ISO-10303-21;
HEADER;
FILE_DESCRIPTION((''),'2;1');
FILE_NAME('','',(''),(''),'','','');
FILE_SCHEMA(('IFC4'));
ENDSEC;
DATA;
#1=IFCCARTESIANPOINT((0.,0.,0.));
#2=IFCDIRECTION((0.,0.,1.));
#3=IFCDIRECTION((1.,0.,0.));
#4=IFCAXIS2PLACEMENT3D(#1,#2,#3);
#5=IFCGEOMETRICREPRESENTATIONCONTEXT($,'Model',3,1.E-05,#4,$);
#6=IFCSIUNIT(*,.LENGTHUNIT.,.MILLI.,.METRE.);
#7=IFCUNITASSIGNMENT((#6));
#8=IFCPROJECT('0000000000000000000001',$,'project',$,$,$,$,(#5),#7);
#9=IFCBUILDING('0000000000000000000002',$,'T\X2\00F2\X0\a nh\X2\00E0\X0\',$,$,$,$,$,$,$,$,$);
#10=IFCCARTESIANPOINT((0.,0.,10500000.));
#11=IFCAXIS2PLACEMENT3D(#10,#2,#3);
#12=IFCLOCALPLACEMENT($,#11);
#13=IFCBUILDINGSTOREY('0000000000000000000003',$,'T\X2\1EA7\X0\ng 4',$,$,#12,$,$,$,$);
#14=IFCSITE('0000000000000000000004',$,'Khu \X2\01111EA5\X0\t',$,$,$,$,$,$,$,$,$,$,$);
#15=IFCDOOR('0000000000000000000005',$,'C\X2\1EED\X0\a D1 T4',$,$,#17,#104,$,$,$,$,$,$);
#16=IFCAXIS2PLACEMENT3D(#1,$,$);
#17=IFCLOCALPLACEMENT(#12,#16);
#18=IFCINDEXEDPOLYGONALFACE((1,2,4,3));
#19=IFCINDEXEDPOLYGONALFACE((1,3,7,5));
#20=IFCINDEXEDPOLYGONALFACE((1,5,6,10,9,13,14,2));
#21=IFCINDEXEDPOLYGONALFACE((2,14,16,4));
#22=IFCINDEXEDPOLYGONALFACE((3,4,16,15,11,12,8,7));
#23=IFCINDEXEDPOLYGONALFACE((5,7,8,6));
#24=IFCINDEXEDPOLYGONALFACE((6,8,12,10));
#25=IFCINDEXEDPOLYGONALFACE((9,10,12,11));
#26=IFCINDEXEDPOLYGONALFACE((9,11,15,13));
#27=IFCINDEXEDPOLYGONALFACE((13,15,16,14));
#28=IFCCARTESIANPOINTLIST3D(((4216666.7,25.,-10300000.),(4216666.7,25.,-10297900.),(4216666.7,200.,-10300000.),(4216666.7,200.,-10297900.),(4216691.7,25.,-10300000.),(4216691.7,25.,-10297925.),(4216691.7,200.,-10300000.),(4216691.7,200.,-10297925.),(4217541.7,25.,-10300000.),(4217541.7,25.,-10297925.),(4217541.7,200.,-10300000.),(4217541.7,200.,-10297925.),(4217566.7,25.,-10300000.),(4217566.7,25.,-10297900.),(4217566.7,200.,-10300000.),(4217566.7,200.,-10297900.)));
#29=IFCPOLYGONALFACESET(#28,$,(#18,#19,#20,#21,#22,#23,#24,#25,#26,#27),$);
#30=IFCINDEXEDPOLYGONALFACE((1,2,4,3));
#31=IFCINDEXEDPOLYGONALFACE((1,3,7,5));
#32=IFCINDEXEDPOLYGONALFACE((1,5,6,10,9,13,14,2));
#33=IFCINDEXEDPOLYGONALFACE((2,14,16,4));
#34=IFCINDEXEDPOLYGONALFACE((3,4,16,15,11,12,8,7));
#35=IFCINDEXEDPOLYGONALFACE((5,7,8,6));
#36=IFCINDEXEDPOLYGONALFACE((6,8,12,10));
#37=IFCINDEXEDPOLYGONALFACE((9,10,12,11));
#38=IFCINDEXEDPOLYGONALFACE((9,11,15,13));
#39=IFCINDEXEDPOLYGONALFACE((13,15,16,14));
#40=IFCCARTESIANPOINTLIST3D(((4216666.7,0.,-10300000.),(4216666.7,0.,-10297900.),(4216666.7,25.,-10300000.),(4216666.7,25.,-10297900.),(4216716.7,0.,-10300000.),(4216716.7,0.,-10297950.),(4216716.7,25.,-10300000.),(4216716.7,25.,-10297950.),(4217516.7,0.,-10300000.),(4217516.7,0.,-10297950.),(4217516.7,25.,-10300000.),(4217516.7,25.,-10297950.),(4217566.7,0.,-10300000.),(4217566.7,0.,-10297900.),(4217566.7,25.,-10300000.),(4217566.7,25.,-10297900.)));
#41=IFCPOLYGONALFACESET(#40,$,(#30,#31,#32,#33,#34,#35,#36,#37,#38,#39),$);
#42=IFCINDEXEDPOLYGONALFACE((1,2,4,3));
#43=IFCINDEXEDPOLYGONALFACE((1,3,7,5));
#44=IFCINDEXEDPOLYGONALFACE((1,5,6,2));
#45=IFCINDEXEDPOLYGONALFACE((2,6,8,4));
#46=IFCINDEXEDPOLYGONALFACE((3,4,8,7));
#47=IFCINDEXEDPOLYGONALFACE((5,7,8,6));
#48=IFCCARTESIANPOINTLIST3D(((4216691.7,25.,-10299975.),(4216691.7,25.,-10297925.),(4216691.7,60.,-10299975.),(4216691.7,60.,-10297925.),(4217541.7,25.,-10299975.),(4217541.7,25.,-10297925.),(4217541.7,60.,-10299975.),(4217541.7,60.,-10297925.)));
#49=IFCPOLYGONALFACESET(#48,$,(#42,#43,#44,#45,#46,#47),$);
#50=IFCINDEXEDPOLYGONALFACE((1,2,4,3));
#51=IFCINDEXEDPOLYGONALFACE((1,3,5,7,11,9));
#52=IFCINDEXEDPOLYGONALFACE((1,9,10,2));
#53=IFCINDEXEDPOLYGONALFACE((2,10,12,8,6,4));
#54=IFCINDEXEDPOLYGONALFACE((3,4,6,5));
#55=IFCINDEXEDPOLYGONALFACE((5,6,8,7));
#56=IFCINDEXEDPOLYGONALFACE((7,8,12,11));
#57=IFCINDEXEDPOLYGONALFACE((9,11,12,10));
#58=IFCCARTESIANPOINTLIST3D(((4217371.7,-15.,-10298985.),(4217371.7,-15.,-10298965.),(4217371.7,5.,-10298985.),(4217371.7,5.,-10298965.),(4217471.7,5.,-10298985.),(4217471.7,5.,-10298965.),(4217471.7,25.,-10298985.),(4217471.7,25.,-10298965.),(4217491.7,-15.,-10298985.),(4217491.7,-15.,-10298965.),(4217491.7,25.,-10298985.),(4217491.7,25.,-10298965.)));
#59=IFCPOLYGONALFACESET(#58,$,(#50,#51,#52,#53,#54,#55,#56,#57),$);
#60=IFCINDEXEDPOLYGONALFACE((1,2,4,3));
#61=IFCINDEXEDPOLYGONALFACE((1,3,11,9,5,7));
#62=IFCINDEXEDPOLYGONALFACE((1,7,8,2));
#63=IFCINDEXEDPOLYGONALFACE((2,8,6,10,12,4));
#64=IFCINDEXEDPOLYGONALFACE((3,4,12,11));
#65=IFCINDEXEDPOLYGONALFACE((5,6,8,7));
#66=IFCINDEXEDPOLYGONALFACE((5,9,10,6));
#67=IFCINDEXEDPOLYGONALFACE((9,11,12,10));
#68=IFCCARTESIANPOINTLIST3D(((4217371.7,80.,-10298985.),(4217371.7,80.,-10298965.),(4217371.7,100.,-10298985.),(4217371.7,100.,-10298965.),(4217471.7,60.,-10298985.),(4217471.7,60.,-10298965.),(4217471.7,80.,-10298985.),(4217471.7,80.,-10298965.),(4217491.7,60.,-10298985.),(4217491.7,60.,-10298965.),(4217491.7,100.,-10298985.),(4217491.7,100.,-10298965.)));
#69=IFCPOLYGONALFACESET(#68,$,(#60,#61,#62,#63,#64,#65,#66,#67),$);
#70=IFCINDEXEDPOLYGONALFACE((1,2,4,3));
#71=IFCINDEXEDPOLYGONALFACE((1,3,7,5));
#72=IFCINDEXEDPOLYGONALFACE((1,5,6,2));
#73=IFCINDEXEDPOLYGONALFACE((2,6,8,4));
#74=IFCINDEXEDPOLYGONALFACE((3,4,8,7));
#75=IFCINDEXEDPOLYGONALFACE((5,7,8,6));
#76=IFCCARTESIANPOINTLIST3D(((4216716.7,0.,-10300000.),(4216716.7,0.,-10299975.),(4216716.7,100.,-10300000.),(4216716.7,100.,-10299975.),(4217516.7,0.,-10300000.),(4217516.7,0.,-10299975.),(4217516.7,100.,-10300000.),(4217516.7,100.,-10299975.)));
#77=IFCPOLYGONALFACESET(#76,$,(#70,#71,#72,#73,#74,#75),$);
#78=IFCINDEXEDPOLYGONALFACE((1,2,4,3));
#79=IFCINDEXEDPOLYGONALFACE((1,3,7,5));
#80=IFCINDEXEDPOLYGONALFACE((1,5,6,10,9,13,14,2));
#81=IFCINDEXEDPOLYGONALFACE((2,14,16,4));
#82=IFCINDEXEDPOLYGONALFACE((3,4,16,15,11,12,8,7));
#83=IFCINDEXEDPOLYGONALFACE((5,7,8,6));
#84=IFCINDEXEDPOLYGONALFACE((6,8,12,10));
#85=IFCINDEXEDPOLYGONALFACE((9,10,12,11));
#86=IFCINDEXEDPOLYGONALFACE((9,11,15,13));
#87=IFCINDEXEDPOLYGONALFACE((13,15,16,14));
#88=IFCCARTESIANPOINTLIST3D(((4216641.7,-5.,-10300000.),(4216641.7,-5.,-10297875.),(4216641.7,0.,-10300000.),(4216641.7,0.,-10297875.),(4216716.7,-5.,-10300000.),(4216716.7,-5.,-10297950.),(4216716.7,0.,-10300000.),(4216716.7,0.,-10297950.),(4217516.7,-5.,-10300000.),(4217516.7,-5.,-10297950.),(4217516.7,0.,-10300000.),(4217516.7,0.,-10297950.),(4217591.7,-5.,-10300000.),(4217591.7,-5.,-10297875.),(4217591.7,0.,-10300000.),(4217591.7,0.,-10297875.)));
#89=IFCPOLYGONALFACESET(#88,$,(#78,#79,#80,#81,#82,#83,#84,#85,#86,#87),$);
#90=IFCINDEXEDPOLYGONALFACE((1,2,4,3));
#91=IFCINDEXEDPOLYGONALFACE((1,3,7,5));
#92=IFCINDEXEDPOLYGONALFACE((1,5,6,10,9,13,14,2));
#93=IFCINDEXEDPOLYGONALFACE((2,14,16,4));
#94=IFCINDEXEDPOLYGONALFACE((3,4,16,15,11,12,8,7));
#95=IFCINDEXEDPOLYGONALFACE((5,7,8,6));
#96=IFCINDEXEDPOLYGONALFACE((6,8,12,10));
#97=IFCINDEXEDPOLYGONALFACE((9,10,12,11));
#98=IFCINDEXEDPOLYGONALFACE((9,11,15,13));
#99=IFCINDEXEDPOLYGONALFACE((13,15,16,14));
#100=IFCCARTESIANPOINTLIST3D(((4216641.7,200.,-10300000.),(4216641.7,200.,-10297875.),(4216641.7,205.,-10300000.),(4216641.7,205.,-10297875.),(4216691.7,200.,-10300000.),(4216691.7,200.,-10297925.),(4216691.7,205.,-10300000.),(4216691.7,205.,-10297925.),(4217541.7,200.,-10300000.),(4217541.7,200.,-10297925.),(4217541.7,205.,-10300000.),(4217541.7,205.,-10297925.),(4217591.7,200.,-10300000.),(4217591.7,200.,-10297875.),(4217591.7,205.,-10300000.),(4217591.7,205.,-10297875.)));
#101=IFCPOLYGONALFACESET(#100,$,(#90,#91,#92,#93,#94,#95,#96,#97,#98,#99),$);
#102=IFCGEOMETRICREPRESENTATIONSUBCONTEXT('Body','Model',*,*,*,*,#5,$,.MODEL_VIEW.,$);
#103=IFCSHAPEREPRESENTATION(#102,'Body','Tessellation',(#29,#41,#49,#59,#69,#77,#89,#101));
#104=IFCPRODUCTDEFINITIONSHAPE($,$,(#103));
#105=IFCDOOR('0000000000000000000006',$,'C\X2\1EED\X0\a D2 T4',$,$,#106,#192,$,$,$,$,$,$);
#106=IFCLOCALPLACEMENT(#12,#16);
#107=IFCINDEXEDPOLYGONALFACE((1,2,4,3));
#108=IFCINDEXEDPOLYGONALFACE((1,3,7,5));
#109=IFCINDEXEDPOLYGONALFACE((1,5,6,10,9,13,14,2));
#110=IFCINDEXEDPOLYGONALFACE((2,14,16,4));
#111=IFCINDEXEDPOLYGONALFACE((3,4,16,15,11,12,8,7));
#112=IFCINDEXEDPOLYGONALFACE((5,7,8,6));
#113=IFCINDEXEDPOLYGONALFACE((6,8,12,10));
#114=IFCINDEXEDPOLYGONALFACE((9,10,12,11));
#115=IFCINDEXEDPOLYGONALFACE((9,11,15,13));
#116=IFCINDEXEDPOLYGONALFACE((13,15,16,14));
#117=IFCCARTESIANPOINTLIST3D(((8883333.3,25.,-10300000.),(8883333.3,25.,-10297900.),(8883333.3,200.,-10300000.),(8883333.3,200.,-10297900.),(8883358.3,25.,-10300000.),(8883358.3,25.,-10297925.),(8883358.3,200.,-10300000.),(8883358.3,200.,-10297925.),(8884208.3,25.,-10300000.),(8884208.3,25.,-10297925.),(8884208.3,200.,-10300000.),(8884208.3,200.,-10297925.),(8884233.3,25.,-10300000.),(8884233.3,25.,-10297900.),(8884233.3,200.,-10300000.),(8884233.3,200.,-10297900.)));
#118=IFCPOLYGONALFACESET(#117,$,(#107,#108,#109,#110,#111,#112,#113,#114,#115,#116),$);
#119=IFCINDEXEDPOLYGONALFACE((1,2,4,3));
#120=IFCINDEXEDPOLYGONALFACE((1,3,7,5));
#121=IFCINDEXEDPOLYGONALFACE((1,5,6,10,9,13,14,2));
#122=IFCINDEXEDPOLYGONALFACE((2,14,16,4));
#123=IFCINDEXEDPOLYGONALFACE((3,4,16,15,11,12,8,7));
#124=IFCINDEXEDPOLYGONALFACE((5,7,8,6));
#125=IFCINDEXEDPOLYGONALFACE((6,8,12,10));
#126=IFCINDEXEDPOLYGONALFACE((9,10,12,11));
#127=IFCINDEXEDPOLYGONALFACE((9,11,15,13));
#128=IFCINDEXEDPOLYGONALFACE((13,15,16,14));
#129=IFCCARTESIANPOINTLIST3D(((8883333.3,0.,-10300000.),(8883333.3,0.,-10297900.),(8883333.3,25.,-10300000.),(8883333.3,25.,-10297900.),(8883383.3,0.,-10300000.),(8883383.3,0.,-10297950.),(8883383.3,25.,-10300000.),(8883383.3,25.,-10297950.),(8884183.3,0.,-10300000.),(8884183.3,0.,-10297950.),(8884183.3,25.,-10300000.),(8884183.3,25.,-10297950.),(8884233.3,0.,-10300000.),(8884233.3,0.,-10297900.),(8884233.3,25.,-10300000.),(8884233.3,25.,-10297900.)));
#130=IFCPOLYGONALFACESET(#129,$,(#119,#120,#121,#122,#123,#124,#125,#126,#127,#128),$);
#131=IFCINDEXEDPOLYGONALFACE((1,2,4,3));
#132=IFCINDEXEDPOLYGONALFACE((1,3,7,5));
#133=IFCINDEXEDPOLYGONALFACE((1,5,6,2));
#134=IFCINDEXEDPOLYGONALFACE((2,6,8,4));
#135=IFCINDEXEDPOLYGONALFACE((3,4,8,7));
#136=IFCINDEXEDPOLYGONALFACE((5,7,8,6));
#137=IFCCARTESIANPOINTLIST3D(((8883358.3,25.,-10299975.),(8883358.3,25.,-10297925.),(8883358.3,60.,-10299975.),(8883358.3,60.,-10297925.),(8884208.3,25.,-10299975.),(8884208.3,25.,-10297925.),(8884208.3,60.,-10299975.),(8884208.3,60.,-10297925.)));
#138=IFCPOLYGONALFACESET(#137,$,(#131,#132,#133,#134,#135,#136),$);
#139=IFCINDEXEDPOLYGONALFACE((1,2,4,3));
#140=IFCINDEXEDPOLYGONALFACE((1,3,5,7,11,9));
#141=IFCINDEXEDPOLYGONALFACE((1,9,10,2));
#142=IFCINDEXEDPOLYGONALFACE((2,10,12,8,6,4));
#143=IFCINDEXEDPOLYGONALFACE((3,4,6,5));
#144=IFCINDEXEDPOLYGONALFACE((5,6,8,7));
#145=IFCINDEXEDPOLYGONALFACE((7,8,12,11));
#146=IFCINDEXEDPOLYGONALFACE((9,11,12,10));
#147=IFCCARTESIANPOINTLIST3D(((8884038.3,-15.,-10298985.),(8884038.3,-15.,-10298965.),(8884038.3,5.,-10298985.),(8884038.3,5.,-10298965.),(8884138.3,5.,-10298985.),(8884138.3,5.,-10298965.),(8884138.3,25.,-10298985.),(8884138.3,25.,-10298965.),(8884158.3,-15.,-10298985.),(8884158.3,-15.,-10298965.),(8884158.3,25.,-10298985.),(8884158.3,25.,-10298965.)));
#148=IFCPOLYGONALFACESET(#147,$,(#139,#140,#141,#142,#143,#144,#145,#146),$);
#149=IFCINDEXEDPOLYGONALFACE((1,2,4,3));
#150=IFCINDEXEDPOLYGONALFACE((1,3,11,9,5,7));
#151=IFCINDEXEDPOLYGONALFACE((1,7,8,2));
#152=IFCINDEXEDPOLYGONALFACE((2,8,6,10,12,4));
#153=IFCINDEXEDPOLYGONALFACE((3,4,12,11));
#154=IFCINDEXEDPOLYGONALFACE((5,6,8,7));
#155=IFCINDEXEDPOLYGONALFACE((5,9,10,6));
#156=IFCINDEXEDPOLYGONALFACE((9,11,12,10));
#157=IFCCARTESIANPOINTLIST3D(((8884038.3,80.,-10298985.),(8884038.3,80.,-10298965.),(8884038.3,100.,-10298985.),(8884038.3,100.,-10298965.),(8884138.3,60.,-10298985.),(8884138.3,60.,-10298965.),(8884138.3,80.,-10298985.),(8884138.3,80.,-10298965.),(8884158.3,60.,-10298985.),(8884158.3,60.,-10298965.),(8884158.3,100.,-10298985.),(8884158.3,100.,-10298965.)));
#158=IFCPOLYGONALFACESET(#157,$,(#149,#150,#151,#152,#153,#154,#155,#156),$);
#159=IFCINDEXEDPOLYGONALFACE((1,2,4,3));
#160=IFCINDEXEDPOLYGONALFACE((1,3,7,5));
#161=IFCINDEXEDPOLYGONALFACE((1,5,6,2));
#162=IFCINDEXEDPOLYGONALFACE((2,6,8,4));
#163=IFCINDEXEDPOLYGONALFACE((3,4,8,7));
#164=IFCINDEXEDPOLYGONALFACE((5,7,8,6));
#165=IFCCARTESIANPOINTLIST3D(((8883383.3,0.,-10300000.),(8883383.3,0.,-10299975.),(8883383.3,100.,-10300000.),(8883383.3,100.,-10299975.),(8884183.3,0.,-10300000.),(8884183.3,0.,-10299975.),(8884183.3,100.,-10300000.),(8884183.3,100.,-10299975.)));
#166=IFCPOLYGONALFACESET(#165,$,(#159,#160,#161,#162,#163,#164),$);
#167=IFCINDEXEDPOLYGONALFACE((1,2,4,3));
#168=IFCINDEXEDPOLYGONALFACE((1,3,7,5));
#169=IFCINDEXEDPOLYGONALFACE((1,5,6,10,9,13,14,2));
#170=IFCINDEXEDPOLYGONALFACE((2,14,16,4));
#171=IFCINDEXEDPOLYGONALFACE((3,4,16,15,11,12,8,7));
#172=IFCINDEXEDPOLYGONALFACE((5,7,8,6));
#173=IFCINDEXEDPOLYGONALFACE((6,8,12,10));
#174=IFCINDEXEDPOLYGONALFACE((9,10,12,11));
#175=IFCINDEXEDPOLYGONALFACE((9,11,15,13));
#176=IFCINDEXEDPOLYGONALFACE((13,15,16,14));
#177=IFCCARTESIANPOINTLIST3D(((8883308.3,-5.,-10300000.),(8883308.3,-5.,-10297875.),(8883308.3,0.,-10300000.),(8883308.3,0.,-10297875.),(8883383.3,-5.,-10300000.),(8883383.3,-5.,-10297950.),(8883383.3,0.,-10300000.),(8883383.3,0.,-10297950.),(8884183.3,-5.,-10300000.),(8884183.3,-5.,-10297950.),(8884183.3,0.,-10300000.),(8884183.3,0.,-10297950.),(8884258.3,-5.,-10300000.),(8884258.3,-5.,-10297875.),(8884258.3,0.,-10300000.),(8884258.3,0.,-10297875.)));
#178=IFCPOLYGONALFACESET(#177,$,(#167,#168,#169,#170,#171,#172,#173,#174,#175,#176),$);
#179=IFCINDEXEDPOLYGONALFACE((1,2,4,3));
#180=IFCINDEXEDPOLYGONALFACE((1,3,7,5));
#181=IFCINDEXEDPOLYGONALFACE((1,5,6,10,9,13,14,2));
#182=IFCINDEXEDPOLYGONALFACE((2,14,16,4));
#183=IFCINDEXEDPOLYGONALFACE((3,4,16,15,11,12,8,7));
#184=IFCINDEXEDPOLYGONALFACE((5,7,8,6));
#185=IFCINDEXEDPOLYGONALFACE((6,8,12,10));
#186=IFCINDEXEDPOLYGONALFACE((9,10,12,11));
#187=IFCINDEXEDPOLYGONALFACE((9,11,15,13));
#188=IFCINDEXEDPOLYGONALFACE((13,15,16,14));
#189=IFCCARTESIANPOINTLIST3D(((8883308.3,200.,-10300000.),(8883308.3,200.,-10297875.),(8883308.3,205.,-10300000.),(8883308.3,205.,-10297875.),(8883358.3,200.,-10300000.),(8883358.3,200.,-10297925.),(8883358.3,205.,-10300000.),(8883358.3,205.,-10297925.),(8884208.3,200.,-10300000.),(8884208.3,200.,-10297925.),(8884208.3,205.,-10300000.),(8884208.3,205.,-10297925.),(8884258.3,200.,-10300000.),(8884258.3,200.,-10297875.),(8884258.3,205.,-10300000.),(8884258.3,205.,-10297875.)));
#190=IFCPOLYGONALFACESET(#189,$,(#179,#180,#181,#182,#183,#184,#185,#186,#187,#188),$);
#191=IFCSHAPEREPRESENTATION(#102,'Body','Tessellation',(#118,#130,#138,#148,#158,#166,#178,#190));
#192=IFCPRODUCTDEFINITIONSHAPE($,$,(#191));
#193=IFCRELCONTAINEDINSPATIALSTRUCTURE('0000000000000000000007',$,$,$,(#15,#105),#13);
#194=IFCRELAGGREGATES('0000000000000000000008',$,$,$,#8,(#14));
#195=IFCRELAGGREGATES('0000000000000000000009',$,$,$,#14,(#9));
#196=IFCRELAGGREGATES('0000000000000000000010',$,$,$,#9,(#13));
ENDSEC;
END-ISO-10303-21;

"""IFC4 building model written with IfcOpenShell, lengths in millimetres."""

from ifc_helpers import new_model, si_unit, frame, origin_with_axes, place, context, subcontext, project, spatial, line, indexed_curve, outline, extrude, element, save


model = new_model("IFC4")

# Units and contexts
model_context = context("Model", 3, precision=1e-05, world=origin_with_axes())
body_context = subcontext(model_context, "Body", "Model", "MODEL_VIEW")
ifc_project = project(units=[si_unit("LENGTHUNIT", "METRE", prefix="MILLI")], contexts=[model_context])

# Site, building, storey
site = spatial("IfcSite", under=ifc_project, Name="Khu đất")
building = spatial("IfcBuilding", under=site, Name="Tòa nhà")
storey_placement = place(None, frame((0.0, 0.0, 10500000.0), z_axis=(0.0, 0.0, 1.0), x_axis=(1.0, 0.0, 0.0)))
storey = spatial("IfcBuildingStorey", under=building, at=storey_placement, Name="Tầng 4")

# Doors
door_1_placement = place(storey_placement, frame((4216666.7, 0.0, -10300000.0), z_axis=(0.0, 0.0, 1.0), x_axis=(1.0, 0.0, 0.0)))
element("IfcDoor", 1, at=door_1_placement, inside=storey, Name="Cửa D1 T4", context=body_context, shape_type="SolidModel", body=[
    extrude(outline(indexed_curve([(0.0, 0.0), (0.0, 2100.0), (900.0, 2100.0), (900.0, 0.0), (875.0, 0.0), (875.0, 2075.0), (25.0, 2075.0), (25.0, 0.0)], segments=[line(1, 2, 3, 4, 5, 6, 7, 8, 1)])), frame((0.0, 25.0, 0.0), z_axis=(0.0, -1.0, 0.0), x_axis=(1.0, 0.0, 0.0)), (0.0, 0.0, -1.0), 175.0),
    extrude(outline(indexed_curve([(0.0, 0.0), (0.0, 2100.0), (900.0, 2100.0), (900.0, 0.0), (850.0, 0.0), (850.0, 2050.0), (50.0, 2050.0), (50.0, 0.0)], segments=[line(1, 2, 3, 4, 5, 6, 7, 8, 1)])), frame((0.0, 0.0, 0.0), z_axis=(0.0, -1.0, 0.0), x_axis=(1.0, 0.0, 0.0)), (0.0, 0.0, -1.0), 25.0),
    extrude(outline(indexed_curve([(0.0, 0.0), (850.0, 0.0), (850.0, 35.0), (0.0, 35.0)], segments=[line(1, 2, 3, 4, 1)])), frame((25.0, 25.0, 25.0), z_axis=(0.0, 0.0, 1.0), x_axis=(1.0, 0.0, 0.0)), (0.0, 0.0, 1.0), 2050.0),
    extrude(outline(indexed_curve([(0.0, 0.0), (0.0, -40.0), (-120.0, -40.0), (-120.0, -20.0), (-20.0, -20.0), (-20.0, 0.0)], segments=[line(1, 2, 3, 4, 5, 6, 1)])), frame((825.0, 25.0, 1015.0), z_axis=(0.0, 0.0, 1.0), x_axis=(1.0, 0.0, 0.0)), (0.0, 0.0, 1.0), 20.0),
    extrude(outline(indexed_curve([(0.0, 0.0), (0.0, 40.0), (-120.0, 40.0), (-120.0, 20.0), (-20.0, 20.0), (-20.0, 0.0)], segments=[line(1, 2, 3, 4, 5, 6, 1)])), frame((825.0, 60.0, 1015.0), z_axis=(0.0, 0.0, 1.0), x_axis=(1.0, 0.0, 0.0)), (0.0, 0.0, 1.0), 20.0),
    extrude(outline(indexed_curve([(0.0, 0.0), (800.0, 0.0), (800.0, 100.0), (0.0, 100.0)], segments=[line(1, 2, 3, 4, 1)])), frame((50.0, 0.0, 0.0), z_axis=(0.0, 0.0, 1.0), x_axis=(1.0, 0.0, 0.0)), (0.0, 0.0, 1.0), 25.0),
    extrude(outline(indexed_curve([(0.0, 0.0), (0.0, 2125.0), (950.0, 2125.0), (950.0, 0.0), (875.0, 0.0), (875.0, 2050.0), (75.0, 2050.0), (75.0, 0.0)], segments=[line(1, 2, 3, 4, 5, 6, 7, 8, 1)])), frame((-25.0, -5.0, 0.0), z_axis=(0.0, -1.0, 0.0), x_axis=(1.0, 0.0, 0.0)), (0.0, 0.0, -1.0), 5.0),
    extrude(outline(indexed_curve([(0.0, 0.0), (0.0, 2125.0), (950.0, 2125.0), (950.0, 0.0), (900.0, 0.0), (900.0, 2075.0), (50.0, 2075.0), (50.0, 0.0)], segments=[line(1, 2, 3, 4, 5, 6, 7, 8, 1)])), frame((-25.0, 200.0, 0.0), z_axis=(0.0, -1.0, 0.0), x_axis=(1.0, 0.0, 0.0)), (0.0, 0.0, -1.0), 5.0),
])
door_2_placement = place(storey_placement, frame((8883333.3, 0.0, -10300000.0), z_axis=(0.0, 0.0, 1.0), x_axis=(1.0, 0.0, 0.0)))
element("IfcDoor", 2, at=door_2_placement, inside=storey, Name="Cửa D2 T4", context=body_context, shape_type="SolidModel", body=[
    extrude(outline(indexed_curve([(0.0, 0.0), (0.0, 2100.0), (900.0, 2100.0), (900.0, 0.0), (875.0, 0.0), (875.0, 2075.0), (25.0, 2075.0), (25.0, 0.0)], segments=[line(1, 2, 3, 4, 5, 6, 7, 8, 1)])), frame((0.0, 25.0, 0.0), z_axis=(0.0, -1.0, 0.0), x_axis=(1.0, 0.0, 0.0)), (0.0, 0.0, -1.0), 175.0),
    extrude(outline(indexed_curve([(0.0, 0.0), (0.0, 2100.0), (900.0, 2100.0), (900.0, 0.0), (850.0, 0.0), (850.0, 2050.0), (50.0, 2050.0), (50.0, 0.0)], segments=[line(1, 2, 3, 4, 5, 6, 7, 8, 1)])), frame((0.0, 0.0, 0.0), z_axis=(0.0, -1.0, 0.0), x_axis=(1.0, 0.0, 0.0)), (0.0, 0.0, -1.0), 25.0),
    extrude(outline(indexed_curve([(0.0, 0.0), (850.0, 0.0), (850.0, 35.0), (0.0, 35.0)], segments=[line(1, 2, 3, 4, 1)])), frame((25.0, 25.0, 25.0), z_axis=(0.0, 0.0, 1.0), x_axis=(1.0, 0.0, 0.0)), (0.0, 0.0, 1.0), 2050.0),
    extrude(outline(indexed_curve([(0.0, 0.0), (0.0, -40.0), (-120.0, -40.0), (-120.0, -20.0), (-20.0, -20.0), (-20.0, 0.0)], segments=[line(1, 2, 3, 4, 5, 6, 1)])), frame((825.0, 25.0, 1015.0), z_axis=(0.0, 0.0, 1.0), x_axis=(1.0, 0.0, 0.0)), (0.0, 0.0, 1.0), 20.0),
    extrude(outline(indexed_curve([(0.0, 0.0), (0.0, 40.0), (-120.0, 40.0), (-120.0, 20.0), (-20.0, 20.0), (-20.0, 0.0)], segments=[line(1, 2, 3, 4, 5, 6, 1)])), frame((825.0, 60.0, 1015.0), z_axis=(0.0, 0.0, 1.0), x_axis=(1.0, 0.0, 0.0)), (0.0, 0.0, 1.0), 20.0),
    extrude(outline(indexed_curve([(0.0, 0.0), (800.0, 0.0), (800.0, 100.0), (0.0, 100.0)], segments=[line(1, 2, 3, 4, 1)])), frame((50.0, 0.0, 0.0), z_axis=(0.0, 0.0, 1.0), x_axis=(1.0, 0.0, 0.0)), (0.0, 0.0, 1.0), 25.0),
    extrude(outline(indexed_curve([(0.0, 0.0), (0.0, 2125.0), (950.0, 2125.0), (950.0, 0.0), (875.0, 0.0), (875.0, 2050.0), (75.0, 2050.0), (75.0, 0.0)], segments=[line(1, 2, 3, 4, 5, 6, 7, 8, 1)])), frame((-25.0, -5.0, 0.0), z_axis=(0.0, -1.0, 0.0), x_axis=(1.0, 0.0, 0.0)), (0.0, 0.0, -1.0), 5.0),
    extrude(outline(indexed_curve([(0.0, 0.0), (0.0, 2125.0), (950.0, 2125.0), (950.0, 0.0), (900.0, 0.0), (900.0, 2075.0), (50.0, 2075.0), (50.0, 0.0)], segments=[line(1, 2, 3, 4, 5, 6, 7, 8, 1)])), frame((-25.0, 200.0, 0.0), z_axis=(0.0, -1.0, 0.0), x_axis=(1.0, 0.0, 0.0)), (0.0, 0.0, -1.0), 5.0),
])

save(model, "model.ifc")
